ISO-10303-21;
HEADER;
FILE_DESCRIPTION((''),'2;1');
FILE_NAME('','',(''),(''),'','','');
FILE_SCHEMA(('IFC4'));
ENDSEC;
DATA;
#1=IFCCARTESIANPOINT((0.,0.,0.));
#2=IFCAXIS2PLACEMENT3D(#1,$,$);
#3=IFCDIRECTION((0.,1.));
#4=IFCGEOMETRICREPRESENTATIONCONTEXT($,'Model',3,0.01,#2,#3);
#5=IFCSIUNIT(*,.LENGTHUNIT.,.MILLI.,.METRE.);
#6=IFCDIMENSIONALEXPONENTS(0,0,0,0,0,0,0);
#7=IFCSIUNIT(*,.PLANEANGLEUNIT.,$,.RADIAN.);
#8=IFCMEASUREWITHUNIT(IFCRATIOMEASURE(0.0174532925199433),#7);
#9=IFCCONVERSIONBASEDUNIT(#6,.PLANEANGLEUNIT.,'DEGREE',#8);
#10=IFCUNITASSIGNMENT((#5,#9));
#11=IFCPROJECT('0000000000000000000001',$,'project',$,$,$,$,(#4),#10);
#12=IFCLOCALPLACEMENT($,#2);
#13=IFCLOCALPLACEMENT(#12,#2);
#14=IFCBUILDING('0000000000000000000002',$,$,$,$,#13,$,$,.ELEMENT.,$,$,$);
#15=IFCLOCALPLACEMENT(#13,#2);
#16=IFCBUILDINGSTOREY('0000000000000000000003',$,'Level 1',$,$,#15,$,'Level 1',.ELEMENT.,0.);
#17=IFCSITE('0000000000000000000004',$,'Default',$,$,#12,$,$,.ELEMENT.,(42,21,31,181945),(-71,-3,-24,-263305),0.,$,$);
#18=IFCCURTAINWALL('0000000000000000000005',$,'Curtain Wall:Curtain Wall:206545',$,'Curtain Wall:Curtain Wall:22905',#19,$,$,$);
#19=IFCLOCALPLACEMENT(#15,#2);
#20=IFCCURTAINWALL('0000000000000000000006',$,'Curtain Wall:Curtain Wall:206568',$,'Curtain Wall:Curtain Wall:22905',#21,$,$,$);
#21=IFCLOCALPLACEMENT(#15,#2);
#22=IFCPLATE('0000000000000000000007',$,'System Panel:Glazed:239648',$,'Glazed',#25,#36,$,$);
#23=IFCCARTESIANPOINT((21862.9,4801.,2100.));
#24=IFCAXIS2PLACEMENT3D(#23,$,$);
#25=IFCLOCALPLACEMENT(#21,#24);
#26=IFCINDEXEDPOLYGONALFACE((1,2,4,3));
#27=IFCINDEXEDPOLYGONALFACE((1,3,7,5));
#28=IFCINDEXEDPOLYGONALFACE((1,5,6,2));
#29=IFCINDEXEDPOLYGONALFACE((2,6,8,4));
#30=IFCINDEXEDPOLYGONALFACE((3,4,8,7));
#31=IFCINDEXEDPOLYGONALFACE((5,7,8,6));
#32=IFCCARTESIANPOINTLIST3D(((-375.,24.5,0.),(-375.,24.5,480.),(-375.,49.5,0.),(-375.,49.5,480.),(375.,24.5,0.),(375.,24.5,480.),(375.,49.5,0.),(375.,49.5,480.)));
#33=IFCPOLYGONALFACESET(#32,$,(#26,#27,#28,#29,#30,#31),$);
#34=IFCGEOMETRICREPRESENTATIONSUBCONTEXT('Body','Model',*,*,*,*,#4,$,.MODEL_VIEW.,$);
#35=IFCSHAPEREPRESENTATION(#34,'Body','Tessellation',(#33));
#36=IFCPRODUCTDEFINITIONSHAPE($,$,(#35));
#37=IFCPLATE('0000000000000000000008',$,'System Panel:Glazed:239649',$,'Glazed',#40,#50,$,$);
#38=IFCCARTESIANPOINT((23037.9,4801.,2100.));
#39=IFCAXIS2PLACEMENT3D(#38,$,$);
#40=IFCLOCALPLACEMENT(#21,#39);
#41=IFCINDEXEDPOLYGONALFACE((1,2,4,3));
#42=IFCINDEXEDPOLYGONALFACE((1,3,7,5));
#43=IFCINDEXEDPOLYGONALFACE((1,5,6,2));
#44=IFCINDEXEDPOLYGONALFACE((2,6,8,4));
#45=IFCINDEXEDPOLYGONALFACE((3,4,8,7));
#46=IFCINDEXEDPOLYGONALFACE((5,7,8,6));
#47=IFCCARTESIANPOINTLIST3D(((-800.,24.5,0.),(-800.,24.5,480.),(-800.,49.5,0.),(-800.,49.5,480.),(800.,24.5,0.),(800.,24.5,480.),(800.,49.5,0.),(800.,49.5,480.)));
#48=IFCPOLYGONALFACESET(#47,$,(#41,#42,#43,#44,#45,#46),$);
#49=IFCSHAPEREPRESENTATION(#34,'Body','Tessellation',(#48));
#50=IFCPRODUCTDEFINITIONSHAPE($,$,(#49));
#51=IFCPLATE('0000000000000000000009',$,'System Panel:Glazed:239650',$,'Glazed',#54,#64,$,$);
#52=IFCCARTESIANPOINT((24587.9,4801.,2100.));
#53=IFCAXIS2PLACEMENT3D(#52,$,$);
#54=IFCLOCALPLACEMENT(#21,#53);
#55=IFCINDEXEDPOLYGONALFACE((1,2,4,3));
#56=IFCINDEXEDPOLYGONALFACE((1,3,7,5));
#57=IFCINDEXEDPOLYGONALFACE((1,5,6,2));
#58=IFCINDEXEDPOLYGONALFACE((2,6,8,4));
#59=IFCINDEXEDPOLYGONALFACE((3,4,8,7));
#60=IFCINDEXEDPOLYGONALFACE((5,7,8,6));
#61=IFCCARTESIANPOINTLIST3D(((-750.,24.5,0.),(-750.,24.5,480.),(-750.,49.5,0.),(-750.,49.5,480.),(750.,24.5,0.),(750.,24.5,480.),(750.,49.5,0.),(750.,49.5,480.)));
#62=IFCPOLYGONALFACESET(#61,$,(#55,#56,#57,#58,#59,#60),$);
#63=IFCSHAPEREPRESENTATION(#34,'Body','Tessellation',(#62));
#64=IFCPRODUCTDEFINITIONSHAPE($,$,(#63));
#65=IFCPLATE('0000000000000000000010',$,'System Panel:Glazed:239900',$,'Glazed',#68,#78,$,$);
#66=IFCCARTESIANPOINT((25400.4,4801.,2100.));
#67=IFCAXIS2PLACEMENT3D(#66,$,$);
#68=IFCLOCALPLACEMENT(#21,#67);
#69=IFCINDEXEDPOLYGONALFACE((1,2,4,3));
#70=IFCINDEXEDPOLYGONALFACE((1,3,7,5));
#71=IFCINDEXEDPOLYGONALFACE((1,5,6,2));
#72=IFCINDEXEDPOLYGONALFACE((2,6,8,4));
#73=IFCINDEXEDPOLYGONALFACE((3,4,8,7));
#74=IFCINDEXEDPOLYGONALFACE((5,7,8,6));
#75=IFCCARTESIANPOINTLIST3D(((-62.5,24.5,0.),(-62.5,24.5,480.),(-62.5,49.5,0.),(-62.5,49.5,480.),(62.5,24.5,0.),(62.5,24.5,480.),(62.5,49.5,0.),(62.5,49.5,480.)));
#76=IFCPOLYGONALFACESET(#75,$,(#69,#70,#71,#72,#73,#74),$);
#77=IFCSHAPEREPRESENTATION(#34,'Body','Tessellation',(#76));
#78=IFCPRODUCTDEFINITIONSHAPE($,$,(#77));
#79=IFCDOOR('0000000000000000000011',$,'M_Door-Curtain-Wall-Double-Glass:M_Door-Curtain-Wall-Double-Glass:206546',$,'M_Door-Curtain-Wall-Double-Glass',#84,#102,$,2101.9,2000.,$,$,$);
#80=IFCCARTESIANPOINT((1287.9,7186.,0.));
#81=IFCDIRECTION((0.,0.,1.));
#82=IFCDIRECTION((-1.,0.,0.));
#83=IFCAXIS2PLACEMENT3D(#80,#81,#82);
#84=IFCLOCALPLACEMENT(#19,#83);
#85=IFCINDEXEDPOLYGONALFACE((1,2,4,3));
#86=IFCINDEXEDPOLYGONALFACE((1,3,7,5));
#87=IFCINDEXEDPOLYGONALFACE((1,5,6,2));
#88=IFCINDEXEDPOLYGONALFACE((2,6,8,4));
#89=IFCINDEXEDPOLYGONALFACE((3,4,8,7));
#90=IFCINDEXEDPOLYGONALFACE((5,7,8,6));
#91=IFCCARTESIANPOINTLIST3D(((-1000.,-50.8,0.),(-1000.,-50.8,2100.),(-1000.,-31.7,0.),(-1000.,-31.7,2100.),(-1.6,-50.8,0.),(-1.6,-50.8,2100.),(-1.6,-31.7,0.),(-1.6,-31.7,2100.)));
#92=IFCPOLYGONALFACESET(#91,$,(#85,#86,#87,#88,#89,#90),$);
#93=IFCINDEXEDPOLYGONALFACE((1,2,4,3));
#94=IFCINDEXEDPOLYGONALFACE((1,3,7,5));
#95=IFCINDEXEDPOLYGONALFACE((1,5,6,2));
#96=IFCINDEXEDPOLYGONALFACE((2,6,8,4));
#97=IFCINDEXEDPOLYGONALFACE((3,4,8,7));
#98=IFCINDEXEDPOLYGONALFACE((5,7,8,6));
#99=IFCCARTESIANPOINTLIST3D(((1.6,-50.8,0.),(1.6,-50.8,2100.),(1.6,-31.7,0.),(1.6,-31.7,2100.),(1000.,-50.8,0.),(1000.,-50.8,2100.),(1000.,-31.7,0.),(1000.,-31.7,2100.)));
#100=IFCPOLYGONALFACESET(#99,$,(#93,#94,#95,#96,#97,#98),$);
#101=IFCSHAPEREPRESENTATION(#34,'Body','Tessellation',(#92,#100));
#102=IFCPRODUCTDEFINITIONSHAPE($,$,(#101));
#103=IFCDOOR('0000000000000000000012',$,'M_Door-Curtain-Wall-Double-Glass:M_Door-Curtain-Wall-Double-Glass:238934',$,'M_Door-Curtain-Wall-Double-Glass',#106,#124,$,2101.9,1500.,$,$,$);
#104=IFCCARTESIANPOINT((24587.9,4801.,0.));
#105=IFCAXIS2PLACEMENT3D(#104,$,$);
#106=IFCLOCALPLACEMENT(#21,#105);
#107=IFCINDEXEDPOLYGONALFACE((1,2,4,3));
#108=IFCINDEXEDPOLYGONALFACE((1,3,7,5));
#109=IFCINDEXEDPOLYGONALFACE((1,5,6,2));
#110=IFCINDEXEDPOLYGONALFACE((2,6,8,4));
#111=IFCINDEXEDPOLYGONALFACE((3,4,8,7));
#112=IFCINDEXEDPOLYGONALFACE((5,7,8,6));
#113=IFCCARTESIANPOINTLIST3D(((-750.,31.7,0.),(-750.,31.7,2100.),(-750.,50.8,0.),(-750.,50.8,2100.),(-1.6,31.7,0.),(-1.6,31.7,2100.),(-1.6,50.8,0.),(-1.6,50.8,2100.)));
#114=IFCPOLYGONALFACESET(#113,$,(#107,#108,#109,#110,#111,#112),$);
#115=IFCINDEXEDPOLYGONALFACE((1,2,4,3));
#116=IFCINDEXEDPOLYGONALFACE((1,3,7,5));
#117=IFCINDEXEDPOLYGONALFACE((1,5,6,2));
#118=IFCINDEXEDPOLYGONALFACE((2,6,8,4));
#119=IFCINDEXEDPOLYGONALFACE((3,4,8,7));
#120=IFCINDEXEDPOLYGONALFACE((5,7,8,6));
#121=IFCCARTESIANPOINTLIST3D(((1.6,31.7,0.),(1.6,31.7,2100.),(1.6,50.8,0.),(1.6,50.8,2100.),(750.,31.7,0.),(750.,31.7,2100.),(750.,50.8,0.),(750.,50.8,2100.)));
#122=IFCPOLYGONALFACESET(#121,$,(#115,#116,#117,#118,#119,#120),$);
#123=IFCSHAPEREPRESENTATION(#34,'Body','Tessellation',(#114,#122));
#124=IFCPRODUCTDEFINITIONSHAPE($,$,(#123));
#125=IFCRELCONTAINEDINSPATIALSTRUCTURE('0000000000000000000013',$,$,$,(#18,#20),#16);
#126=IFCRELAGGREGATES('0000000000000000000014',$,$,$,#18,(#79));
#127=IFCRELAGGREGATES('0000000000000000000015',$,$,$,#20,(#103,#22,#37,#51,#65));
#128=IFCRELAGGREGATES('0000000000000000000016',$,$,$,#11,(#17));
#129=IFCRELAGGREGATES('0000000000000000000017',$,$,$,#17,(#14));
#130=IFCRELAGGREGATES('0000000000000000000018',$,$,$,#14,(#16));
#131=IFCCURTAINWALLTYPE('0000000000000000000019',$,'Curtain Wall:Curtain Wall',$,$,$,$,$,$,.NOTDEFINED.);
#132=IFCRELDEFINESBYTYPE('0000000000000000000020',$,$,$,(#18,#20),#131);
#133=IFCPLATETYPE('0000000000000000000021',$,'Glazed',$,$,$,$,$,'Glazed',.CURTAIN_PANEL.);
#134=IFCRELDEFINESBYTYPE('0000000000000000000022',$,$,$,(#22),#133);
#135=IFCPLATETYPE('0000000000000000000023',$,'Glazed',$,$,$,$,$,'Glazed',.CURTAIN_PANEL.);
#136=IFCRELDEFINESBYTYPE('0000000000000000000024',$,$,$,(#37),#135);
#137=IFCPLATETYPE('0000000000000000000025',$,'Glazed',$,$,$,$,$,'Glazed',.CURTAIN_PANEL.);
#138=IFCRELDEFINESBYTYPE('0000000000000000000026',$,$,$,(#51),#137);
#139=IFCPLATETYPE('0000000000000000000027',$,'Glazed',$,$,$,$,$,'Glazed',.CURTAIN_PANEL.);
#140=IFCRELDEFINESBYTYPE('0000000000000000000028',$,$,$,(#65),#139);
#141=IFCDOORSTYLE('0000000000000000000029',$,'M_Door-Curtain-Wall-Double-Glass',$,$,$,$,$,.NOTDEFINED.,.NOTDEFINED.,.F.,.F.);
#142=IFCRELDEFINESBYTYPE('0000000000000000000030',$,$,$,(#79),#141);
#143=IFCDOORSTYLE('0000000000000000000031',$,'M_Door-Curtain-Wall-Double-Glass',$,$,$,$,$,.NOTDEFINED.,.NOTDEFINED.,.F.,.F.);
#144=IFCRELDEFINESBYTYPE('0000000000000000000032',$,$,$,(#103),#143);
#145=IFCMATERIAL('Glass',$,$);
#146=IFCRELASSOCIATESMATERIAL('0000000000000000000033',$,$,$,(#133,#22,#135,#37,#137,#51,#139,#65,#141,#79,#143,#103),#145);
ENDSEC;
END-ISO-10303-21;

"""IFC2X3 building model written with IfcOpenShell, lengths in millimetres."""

from ifc_helpers import new_model, entity, si_unit, converted_unit, direction, frame, frame_2d, origin, origin_2d_with_axis, place, context, subcontext, project, spatial, rectangle, extrude, source, transform, mapped, material, type_object, type_shapes, element, aggregate, save


model = new_model("IFC2X3")

# Units and contexts
model_context = context("Model", 3, precision=0.01, world=origin(), true_north=direction((0.0, 1.0)))
body_context = subcontext(model_context, "Body", "Model", "MODEL_VIEW")
ifc_project = project(units=[si_unit("LENGTHUNIT", "METRE", prefix="MILLI"), converted_unit("PLANEANGLEUNIT", "DEGREE", entity("IfcRatioMeasure", 0.0174532925199433), si_unit("PLANEANGLEUNIT", "RADIAN"), dimensions=[0, 0, 0, 0, 0, 0, 0])], contexts=[model_context])

# Site, building, storey
site_placement = place(None, origin())
site = spatial("IfcSite", under=ifc_project, at=site_placement, Name="Default", CompositionType="ELEMENT", RefLatitude=(42, 21, 31, 181945), RefLongitude=(-71, -3, -24, -263305), RefElevation=0.0)
building_placement = place(site_placement, origin())
building = spatial("IfcBuilding", under=site, at=building_placement, CompositionType="ELEMENT")
storey_placement = place(building_placement, origin())
storey = spatial("IfcBuildingStorey", under=building, at=storey_placement, Name="Level 1", LongName="Level 1", CompositionType="ELEMENT", Elevation=0.0)

# Shared definitions
curtain_wall_type = type_object("IfcCurtainWallType", Name="Curtain Wall:Curtain Wall", PredefinedType="NOTDEFINED")
ifc_material_1 = material(Name="Glass")

# Curtain walls, plates
curtain_wall_1_placement = place(storey_placement, origin())
curtain_wall_1 = element("IfcCurtainWall", 1, at=curtain_wall_1_placement, inside=storey, type_object=curtain_wall_type, Name="Curtain Wall:Curtain Wall:206545", ObjectType="Curtain Wall:Curtain Wall:22905")
curtain_wall_2_placement = place(storey_placement, origin())
curtain_wall_2 = element("IfcCurtainWall", 2, at=curtain_wall_2_placement, inside=storey, type_object=curtain_wall_type, Name="Curtain Wall:Curtain Wall:206568", ObjectType="Curtain Wall:Curtain Wall:22905")
plate_type_1 = type_object("IfcPlateType", Name="Glazed", ElementType="Glazed", PredefinedType="CURTAIN_PANEL", material=ifc_material_1)
shared_shape_1 = source(origin(), body_context, "Body", "SweptSolid", [
    extrude(rectangle(XDim=25.0, YDim=750.0, at=origin_2d_with_axis()), frame((0.0, 37.0, 0.0), z_axis=(0.0, 0.0, 1.0), x_axis=(0.0, 1.0, 0.0)), (0.0, 0.0, 1.0), 480.0),
])
type_shapes(plate_type_1, [shared_shape_1])
plate_1_placement = place(curtain_wall_2_placement, frame((21862.9, 4801.0, 2100.0)))
plate_1 = element("IfcPlate", 3, at=plate_1_placement, type_object=plate_type_1, material=ifc_material_1, Name="System Panel:Glazed:239648", ObjectType="Glazed", context=body_context, shape_type="MappedRepresentation", body=[
    mapped(shared_shape_1, transform((0.0, 0.0, 0.0), scale=1.0)),
])
plate_type_2 = type_object("IfcPlateType", Name="Glazed", ElementType="Glazed", PredefinedType="CURTAIN_PANEL", material=ifc_material_1)
shared_shape_2 = source(origin(), body_context, "Body", "SweptSolid", [
    extrude(rectangle(XDim=25.0, YDim=1600.0, at=origin_2d_with_axis()), frame((0.0, 37.0, 0.0), z_axis=(0.0, 0.0, 1.0), x_axis=(0.0, 1.0, 0.0)), (0.0, 0.0, 1.0), 480.0),
])
type_shapes(plate_type_2, [shared_shape_2])
plate_2_placement = place(curtain_wall_2_placement, frame((23037.9, 4801.0, 2100.0)))
plate_2 = element("IfcPlate", 4, at=plate_2_placement, type_object=plate_type_2, material=ifc_material_1, Name="System Panel:Glazed:239649", ObjectType="Glazed", context=body_context, shape_type="MappedRepresentation", body=[
    mapped(shared_shape_2, transform((0.0, 0.0, 0.0), scale=1.0)),
])
plate_type_3 = type_object("IfcPlateType", Name="Glazed", ElementType="Glazed", PredefinedType="CURTAIN_PANEL", material=ifc_material_1)
shared_shape_3 = source(origin(), body_context, "Body", "SweptSolid", [
    extrude(rectangle(XDim=25.0, YDim=1500.0, at=origin_2d_with_axis()), frame((0.0, 37.0, 0.0), z_axis=(0.0, 0.0, 1.0), x_axis=(0.0, 1.0, 0.0)), (0.0, 0.0, 1.0), 480.0),
])
type_shapes(plate_type_3, [shared_shape_3])
plate_3_placement = place(curtain_wall_2_placement, frame((24587.9, 4801.0, 2100.0)))
plate_3 = element("IfcPlate", 5, at=plate_3_placement, type_object=plate_type_3, material=ifc_material_1, Name="System Panel:Glazed:239650", ObjectType="Glazed", context=body_context, shape_type="MappedRepresentation", body=[
    mapped(shared_shape_3, transform((0.0, 0.0, 0.0), scale=1.0)),
])
plate_type_4 = type_object("IfcPlateType", Name="Glazed", ElementType="Glazed", PredefinedType="CURTAIN_PANEL", material=ifc_material_1)
shared_shape_4 = source(origin(), body_context, "Body", "SweptSolid", [
    extrude(rectangle(XDim=25.0, YDim=125.0, at=origin_2d_with_axis()), frame((0.0, 37.0, 0.0), z_axis=(0.0, 0.0, 1.0), x_axis=(0.0, 1.0, 0.0)), (0.0, 0.0, 1.0), 480.0),
])
type_shapes(plate_type_4, [shared_shape_4])
plate_4_placement = place(curtain_wall_2_placement, frame((25400.4, 4801.0, 2100.0)))
plate_4 = element("IfcPlate", 6, at=plate_4_placement, type_object=plate_type_4, material=ifc_material_1, Name="System Panel:Glazed:239900", ObjectType="Glazed", context=body_context, shape_type="MappedRepresentation", body=[
    mapped(shared_shape_4, transform((0.0, 0.0, 0.0), scale=1.0)),
])

# Doors
door_style_1 = type_object("IfcDoorStyle", Name="M_Door-Curtain-Wall-Double-Glass", ConstructionType="NOTDEFINED", OperationType="NOTDEFINED", ParameterTakesPrecedence=False, Sizeable=False, material=ifc_material_1)
shared_shape_5 = source(origin(), body_context, "Body", "SweptSolid", [
    extrude(rectangle(XDim=998.4, YDim=19.1, at=frame_2d((0.0, 0.0), x_axis=(1.0, 0.0))), frame((-500.8, -41.3, 0.0), z_axis=(0.0, 0.0, 1.0), x_axis=(-1.0, 0.0, 0.0)), (0.0, 0.0, 1.0), 2100.0),
    extrude(rectangle(XDim=998.4, YDim=19.1, at=origin_2d_with_axis()), frame((500.8, -41.3, 0.0), z_axis=(0.0, 0.0, 1.0), x_axis=(-1.0, 0.0, 0.0)), (0.0, 0.0, 1.0), 2100.0),
])
type_shapes(door_style_1, [shared_shape_5])
door_1_placement = place(curtain_wall_1_placement, frame((1287.9, 7186.0, 0.0), z_axis=(0.0, 0.0, 1.0), x_axis=(-1.0, 0.0, 0.0)))
door_1 = element("IfcDoor", 7, at=door_1_placement, type_object=door_style_1, material=ifc_material_1, Name="M_Door-Curtain-Wall-Double-Glass:M_Door-Curtain-Wall-Double-Glass:206546", ObjectType="M_Door-Curtain-Wall-Double-Glass", OverallHeight=2101.9, OverallWidth=2000.0, context=body_context, shape_type="MappedRepresentation", body=[
    mapped(shared_shape_5, transform((0.0, 0.0, 0.0), scale=1.0)),
])
aggregate(curtain_wall_1, [door_1])
door_style_2 = type_object("IfcDoorStyle", Name="M_Door-Curtain-Wall-Double-Glass", ConstructionType="NOTDEFINED", OperationType="NOTDEFINED", ParameterTakesPrecedence=False, Sizeable=False, material=ifc_material_1)
shared_shape_6 = source(origin(), body_context, "Body", "SweptSolid", [
    extrude(rectangle(XDim=19.1, YDim=748.4, at=origin_2d_with_axis()), frame((-375.8, 41.3, 0.0), z_axis=(0.0, 0.0, 1.0), x_axis=(0.0, 1.0, 0.0)), (0.0, 0.0, 1.0), 2100.0),
    extrude(rectangle(XDim=19.1, YDim=748.4, at=origin_2d_with_axis()), frame((375.8, 41.3, 0.0), z_axis=(0.0, 0.0, 1.0), x_axis=(0.0, 1.0, 0.0)), (0.0, 0.0, 1.0), 2100.0),
])
type_shapes(door_style_2, [shared_shape_6])
door_2_placement = place(curtain_wall_2_placement, frame((24587.9, 4801.0, 0.0)))
door_2 = element("IfcDoor", 8, at=door_2_placement, type_object=door_style_2, material=ifc_material_1, Name="M_Door-Curtain-Wall-Double-Glass:M_Door-Curtain-Wall-Double-Glass:238934", ObjectType="M_Door-Curtain-Wall-Double-Glass", OverallHeight=2101.9, OverallWidth=1500.0, context=body_context, shape_type="MappedRepresentation", body=[
    mapped(shared_shape_6, transform((0.0, 0.0, 0.0), scale=1.0)),
])
aggregate(curtain_wall_2, [door_2, plate_1, plate_2, plate_3, plate_4])

save(model, "model.ifc")
